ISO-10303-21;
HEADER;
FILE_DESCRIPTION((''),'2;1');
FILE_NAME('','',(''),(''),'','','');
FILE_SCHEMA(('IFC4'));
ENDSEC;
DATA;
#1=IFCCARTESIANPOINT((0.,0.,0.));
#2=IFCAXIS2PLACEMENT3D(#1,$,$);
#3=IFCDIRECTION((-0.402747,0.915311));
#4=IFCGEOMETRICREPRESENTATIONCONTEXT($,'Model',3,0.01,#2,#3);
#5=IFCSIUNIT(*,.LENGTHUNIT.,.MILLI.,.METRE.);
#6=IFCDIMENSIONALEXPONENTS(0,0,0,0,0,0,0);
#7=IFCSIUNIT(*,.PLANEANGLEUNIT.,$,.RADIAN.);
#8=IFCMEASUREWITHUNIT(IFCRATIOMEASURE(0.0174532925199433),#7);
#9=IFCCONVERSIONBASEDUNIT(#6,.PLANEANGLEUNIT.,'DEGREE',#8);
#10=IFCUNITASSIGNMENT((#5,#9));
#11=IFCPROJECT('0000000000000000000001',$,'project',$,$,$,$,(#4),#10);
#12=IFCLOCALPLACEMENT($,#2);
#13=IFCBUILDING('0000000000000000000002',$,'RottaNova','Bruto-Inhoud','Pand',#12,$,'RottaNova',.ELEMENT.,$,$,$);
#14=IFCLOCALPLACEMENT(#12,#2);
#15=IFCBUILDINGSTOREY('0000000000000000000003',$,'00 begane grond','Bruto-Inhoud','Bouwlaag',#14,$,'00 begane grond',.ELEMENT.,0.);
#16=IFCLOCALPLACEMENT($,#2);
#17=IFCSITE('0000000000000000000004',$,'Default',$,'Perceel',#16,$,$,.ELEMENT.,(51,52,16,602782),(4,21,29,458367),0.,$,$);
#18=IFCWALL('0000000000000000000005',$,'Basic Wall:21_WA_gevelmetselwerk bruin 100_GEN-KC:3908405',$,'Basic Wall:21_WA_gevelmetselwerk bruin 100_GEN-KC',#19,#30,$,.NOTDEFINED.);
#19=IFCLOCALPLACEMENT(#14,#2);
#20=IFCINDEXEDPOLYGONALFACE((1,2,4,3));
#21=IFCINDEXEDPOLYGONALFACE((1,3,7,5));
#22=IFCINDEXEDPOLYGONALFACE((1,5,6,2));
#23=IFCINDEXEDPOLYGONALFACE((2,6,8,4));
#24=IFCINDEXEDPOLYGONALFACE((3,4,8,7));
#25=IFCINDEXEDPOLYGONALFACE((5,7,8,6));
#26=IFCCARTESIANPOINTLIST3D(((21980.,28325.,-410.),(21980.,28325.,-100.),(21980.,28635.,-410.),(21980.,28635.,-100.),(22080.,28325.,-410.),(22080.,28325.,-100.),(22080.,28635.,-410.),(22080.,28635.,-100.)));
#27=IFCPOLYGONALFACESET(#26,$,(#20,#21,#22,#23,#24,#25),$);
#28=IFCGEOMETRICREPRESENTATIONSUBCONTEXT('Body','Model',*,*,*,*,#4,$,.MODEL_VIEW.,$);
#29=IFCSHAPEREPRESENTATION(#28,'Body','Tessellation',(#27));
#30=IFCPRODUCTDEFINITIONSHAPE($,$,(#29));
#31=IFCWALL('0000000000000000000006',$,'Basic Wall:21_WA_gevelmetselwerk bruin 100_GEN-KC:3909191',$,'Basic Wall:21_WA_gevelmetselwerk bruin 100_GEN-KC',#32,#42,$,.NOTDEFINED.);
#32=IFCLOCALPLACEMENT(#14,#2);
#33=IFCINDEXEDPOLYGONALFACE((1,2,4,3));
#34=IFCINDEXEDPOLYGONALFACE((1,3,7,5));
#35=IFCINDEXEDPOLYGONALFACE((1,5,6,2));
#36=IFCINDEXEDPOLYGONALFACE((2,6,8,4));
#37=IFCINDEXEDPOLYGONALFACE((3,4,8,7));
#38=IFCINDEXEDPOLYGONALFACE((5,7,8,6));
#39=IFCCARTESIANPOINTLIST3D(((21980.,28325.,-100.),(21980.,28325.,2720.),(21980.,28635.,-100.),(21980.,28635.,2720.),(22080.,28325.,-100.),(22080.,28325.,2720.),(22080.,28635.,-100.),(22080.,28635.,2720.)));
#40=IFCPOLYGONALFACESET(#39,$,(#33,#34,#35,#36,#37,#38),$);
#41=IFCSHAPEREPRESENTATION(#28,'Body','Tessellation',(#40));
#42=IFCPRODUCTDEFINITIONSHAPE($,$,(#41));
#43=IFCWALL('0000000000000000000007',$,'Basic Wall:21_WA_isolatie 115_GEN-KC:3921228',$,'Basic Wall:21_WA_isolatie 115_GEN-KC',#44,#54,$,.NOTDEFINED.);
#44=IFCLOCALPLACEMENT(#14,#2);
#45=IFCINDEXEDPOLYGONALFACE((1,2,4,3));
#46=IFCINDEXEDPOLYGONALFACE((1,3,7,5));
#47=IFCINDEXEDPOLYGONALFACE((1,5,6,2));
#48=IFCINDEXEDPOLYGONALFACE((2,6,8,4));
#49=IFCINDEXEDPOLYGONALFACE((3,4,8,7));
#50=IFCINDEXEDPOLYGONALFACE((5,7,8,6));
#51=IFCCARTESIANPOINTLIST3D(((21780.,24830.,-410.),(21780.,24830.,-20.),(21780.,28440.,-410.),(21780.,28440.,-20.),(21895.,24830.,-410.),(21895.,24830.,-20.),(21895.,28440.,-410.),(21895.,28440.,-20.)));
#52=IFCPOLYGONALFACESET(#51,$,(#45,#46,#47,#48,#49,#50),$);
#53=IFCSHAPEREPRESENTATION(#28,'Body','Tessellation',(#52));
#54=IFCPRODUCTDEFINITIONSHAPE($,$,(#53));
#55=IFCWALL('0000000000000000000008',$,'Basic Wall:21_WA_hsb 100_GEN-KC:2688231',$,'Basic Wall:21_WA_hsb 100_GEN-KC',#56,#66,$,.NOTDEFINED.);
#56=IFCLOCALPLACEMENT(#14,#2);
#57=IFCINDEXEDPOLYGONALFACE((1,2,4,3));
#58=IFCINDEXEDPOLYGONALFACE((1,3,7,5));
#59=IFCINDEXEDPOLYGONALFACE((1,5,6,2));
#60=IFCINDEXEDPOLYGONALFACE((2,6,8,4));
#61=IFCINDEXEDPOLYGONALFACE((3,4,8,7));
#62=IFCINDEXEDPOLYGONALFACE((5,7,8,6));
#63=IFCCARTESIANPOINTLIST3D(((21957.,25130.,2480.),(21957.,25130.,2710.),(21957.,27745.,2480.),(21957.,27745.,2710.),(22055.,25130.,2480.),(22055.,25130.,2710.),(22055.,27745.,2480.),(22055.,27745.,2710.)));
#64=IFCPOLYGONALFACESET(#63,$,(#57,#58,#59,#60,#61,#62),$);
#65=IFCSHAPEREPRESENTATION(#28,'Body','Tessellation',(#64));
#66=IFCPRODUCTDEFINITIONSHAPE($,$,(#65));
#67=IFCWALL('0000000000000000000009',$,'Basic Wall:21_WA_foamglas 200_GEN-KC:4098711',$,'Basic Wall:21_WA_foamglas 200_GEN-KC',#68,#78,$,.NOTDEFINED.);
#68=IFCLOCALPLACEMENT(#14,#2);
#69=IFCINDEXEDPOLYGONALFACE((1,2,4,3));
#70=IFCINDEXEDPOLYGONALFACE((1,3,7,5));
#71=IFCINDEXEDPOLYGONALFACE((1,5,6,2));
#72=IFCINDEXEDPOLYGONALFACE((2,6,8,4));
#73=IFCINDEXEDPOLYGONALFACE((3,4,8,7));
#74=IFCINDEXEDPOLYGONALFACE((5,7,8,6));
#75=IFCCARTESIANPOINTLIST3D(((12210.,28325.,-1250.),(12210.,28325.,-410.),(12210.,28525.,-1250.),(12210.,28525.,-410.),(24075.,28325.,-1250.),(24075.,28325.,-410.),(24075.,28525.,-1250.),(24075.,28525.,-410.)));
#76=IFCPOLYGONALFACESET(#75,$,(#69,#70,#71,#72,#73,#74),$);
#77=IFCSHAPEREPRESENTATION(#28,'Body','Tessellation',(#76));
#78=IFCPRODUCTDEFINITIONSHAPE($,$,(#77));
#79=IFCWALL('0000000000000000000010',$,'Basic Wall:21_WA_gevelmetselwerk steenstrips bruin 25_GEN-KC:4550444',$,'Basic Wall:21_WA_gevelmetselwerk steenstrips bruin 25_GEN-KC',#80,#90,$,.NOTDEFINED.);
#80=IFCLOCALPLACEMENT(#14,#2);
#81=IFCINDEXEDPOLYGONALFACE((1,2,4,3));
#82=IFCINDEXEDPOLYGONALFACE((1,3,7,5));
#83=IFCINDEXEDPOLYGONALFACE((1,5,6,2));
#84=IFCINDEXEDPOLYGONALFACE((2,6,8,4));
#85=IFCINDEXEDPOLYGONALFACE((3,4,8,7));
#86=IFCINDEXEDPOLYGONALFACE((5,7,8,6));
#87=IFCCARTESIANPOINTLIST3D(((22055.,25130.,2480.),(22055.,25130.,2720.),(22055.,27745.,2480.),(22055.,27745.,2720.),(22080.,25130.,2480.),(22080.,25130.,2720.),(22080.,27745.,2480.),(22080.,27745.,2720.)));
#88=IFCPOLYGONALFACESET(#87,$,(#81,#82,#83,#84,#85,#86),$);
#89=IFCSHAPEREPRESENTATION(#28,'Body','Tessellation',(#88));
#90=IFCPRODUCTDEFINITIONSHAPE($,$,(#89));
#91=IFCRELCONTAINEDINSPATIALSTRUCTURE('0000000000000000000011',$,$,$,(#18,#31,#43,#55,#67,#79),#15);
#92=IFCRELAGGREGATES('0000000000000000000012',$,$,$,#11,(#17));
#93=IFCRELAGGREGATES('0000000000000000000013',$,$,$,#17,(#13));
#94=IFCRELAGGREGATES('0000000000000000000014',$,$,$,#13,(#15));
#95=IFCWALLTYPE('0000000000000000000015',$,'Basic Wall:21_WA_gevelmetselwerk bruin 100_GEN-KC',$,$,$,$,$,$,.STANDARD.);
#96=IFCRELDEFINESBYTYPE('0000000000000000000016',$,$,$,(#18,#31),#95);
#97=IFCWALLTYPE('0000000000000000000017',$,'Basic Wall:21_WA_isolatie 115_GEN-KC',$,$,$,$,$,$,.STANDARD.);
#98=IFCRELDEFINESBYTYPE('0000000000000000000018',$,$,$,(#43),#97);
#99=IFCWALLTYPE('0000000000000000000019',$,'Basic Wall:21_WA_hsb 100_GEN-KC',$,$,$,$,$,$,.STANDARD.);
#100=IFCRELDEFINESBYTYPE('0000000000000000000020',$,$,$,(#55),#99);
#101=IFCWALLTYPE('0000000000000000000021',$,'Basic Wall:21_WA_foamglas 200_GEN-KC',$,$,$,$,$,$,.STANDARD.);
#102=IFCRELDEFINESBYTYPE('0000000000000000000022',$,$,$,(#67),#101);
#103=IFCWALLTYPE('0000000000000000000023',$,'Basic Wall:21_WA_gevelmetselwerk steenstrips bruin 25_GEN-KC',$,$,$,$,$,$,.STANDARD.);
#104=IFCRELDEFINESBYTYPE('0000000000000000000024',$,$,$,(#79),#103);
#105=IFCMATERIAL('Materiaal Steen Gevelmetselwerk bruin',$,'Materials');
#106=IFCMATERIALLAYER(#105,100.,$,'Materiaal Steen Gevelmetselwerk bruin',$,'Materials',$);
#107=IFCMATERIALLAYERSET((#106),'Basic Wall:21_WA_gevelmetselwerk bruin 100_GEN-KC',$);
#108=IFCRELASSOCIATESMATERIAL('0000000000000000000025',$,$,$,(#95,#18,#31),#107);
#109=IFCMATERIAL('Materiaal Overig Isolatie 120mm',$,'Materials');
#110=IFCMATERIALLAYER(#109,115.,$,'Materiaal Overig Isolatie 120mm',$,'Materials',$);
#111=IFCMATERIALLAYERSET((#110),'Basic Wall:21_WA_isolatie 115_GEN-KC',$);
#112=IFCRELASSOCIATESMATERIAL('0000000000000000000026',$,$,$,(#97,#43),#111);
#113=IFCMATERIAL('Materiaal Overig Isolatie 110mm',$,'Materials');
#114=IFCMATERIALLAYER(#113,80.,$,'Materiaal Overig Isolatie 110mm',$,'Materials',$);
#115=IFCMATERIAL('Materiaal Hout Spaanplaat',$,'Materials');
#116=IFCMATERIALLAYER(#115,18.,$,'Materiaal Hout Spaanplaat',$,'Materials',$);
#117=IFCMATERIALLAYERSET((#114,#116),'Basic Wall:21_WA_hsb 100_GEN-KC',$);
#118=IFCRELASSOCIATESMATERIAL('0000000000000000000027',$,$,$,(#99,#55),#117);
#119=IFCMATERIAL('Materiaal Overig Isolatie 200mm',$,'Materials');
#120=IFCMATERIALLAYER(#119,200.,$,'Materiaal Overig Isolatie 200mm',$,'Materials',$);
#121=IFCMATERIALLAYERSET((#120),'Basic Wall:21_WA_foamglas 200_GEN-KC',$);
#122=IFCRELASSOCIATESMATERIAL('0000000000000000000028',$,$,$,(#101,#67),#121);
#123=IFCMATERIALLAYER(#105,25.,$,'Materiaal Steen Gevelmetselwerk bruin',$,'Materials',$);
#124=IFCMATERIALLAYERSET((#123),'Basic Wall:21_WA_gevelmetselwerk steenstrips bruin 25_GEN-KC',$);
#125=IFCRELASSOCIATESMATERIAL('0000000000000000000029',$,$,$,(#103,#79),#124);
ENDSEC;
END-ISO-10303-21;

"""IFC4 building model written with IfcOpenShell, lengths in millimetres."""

from ifc_helpers import new_model, entity, si_unit, converted_unit, direction, frame, frame_2d, origin, place, context, subcontext, project, spatial, rectangle, extrude, material, layer, layer_set, type_object, element, save


model = new_model("IFC4")

# Units and contexts
model_context = context("Model", 3, precision=0.01, world=origin(), true_north=direction((-0.402747, 0.915311)))
body_context = subcontext(model_context, "Body", "Model", "MODEL_VIEW")
ifc_project = project(units=[si_unit("LENGTHUNIT", "METRE", prefix="MILLI"), converted_unit("PLANEANGLEUNIT", "DEGREE", entity("IfcRatioMeasure", 0.0174532925199433), si_unit("PLANEANGLEUNIT", "RADIAN"), dimensions=[0, 0, 0, 0, 0, 0, 0])], contexts=[model_context])

# Site, building, storey
site_placement = place(None, origin())
site = spatial("IfcSite", under=ifc_project, at=site_placement, Name="Default", ObjectType="Perceel", CompositionType="ELEMENT", RefLatitude=(51, 52, 16, 602782), RefLongitude=(4, 21, 29, 458367), RefElevation=0.0)
building_placement = place(None, origin())
building = spatial("IfcBuilding", under=site, at=building_placement, Name="RottaNova", Description="Bruto-Inhoud", ObjectType="Pand", LongName="RottaNova", CompositionType="ELEMENT")
storey_placement = place(building_placement, origin())
storey = spatial("IfcBuildingStorey", under=building, at=storey_placement, Name="00 begane grond", Description="Bruto-Inhoud", ObjectType="Bouwlaag", LongName="00 begane grond", CompositionType="ELEMENT", Elevation=0.0)

# Walls
ifc_material_1 = material(Name="Materiaal Steen Gevelmetselwerk bruin", Category="Materials")
ifc_layer_1 = layer(ifc_material_1, 100.0, Name="Materiaal Steen Gevelmetselwerk bruin", Category="Materials")
ifc_layer_set_1 = layer_set([ifc_layer_1], Name="Basic Wall:21_WA_gevelmetselwerk bruin 100_GEN-KC")
wall_type_1 = type_object("IfcWallType", Name="Basic Wall:21_WA_gevelmetselwerk bruin 100_GEN-KC", PredefinedType="STANDARD", material=ifc_layer_set_1)
wall_1_placement = place(storey_placement, frame((22030.0, 28325.0, -410.0), z_axis=(0.0, 0.0, 1.0), x_axis=(0.0, 1.0, 0.0)))
element("IfcWall", 1, at=wall_1_placement, inside=storey, type_object=wall_type_1, material=ifc_layer_set_1, Name="Basic Wall:21_WA_gevelmetselwerk bruin 100_GEN-KC:3908405", ObjectType="Basic Wall:21_WA_gevelmetselwerk bruin 100_GEN-KC", PredefinedType="NOTDEFINED", context=body_context, shape_type="SweptSolid", body=[
    extrude(rectangle(XDim=310.0, YDim=100.0, at=frame_2d((155.0, 0.0), x_axis=(-1.0, 0.0))), origin(), (0.0, 0.0, 1.0), 310.0),
])
wall_2_placement = place(storey_placement, frame((22030.0, 28325.0, -100.0), z_axis=(0.0, 0.0, 1.0), x_axis=(0.0, 1.0, 0.0)))
element("IfcWall", 2, at=wall_2_placement, inside=storey, type_object=wall_type_1, material=ifc_layer_set_1, Name="Basic Wall:21_WA_gevelmetselwerk bruin 100_GEN-KC:3909191", ObjectType="Basic Wall:21_WA_gevelmetselwerk bruin 100_GEN-KC", PredefinedType="NOTDEFINED", context=body_context, shape_type="SweptSolid", body=[
    extrude(rectangle(XDim=310.0, YDim=100.0, at=frame_2d((155.0, 0.0), x_axis=(-1.0, 0.0))), origin(), (0.0, 0.0, 1.0), 2820.0),
])
ifc_material_2 = material(Name="Materiaal Overig Isolatie 120mm", Category="Materials")
ifc_layer_2 = layer(ifc_material_2, 115.0, Name="Materiaal Overig Isolatie 120mm", Category="Materials")
ifc_layer_set_2 = layer_set([ifc_layer_2], Name="Basic Wall:21_WA_isolatie 115_GEN-KC")
wall_type_2 = type_object("IfcWallType", Name="Basic Wall:21_WA_isolatie 115_GEN-KC", PredefinedType="STANDARD", material=ifc_layer_set_2)
wall_3_placement = place(storey_placement, frame((21837.5, 28440.0, -410.0), z_axis=(0.0, 0.0, 1.0), x_axis=(0.0, -1.0, 0.0)))
element("IfcWall", 3, at=wall_3_placement, inside=storey, type_object=wall_type_2, material=ifc_layer_set_2, Name="Basic Wall:21_WA_isolatie 115_GEN-KC:3921228", ObjectType="Basic Wall:21_WA_isolatie 115_GEN-KC", PredefinedType="NOTDEFINED", context=body_context, shape_type="SweptSolid", body=[
    extrude(rectangle(XDim=3610.0, YDim=115.0, at=frame_2d((1805.0, 0.0), x_axis=(-1.0, 0.0))), origin(), (0.0, 0.0, 1.0), 390.0),
])
ifc_material_3 = material(Name="Materiaal Overig Isolatie 110mm", Category="Materials")
ifc_layer_3 = layer(ifc_material_3, 80.0, Name="Materiaal Overig Isolatie 110mm", Category="Materials")
ifc_material_4 = material(Name="Materiaal Hout Spaanplaat", Category="Materials")
ifc_layer_4 = layer(ifc_material_4, 18.0, Name="Materiaal Hout Spaanplaat", Category="Materials")
ifc_layer_set_3 = layer_set([ifc_layer_3, ifc_layer_4], Name="Basic Wall:21_WA_hsb 100_GEN-KC")
wall_type_3 = type_object("IfcWallType", Name="Basic Wall:21_WA_hsb 100_GEN-KC", PredefinedType="STANDARD", material=ifc_layer_set_3)
wall_4_placement = place(storey_placement, frame((22006.0, 25130.0, 2480.0), z_axis=(0.0, 0.0, 1.0), x_axis=(0.0, 1.0, 0.0)))
element("IfcWall", 4, at=wall_4_placement, inside=storey, type_object=wall_type_3, material=ifc_layer_set_3, Name="Basic Wall:21_WA_hsb 100_GEN-KC:2688231", ObjectType="Basic Wall:21_WA_hsb 100_GEN-KC", PredefinedType="NOTDEFINED", context=body_context, shape_type="SweptSolid", body=[
    extrude(rectangle(XDim=2615.0, YDim=98.0, at=frame_2d((1307.5, 0.0), x_axis=(-1.0, 0.0))), origin(), (0.0, 0.0, 1.0), 230.0),
])
ifc_material_5 = material(Name="Materiaal Overig Isolatie 200mm", Category="Materials")
ifc_layer_5 = layer(ifc_material_5, 200.0, Name="Materiaal Overig Isolatie 200mm", Category="Materials")
ifc_layer_set_4 = layer_set([ifc_layer_5], Name="Basic Wall:21_WA_foamglas 200_GEN-KC")
wall_type_4 = type_object("IfcWallType", Name="Basic Wall:21_WA_foamglas 200_GEN-KC", PredefinedType="STANDARD", material=ifc_layer_set_4)
wall_5_placement = place(storey_placement, frame((24075.0, 28425.0, -1250.0), z_axis=(0.0, 0.0, 1.0), x_axis=(-1.0, 0.0, 0.0)))
element("IfcWall", 5, at=wall_5_placement, inside=storey, type_object=wall_type_4, material=ifc_layer_set_4, Name="Basic Wall:21_WA_foamglas 200_GEN-KC:4098711", ObjectType="Basic Wall:21_WA_foamglas 200_GEN-KC", PredefinedType="NOTDEFINED", context=body_context, shape_type="SweptSolid", body=[
    extrude(rectangle(XDim=11865.0, YDim=200.0, at=frame_2d((5932.5, 0.0), x_axis=(-1.0, 0.0))), origin(), (0.0, 0.0, 1.0), 840.0),
])
ifc_layer_6 = layer(ifc_material_1, 25.0, Name="Materiaal Steen Gevelmetselwerk bruin", Category="Materials")
ifc_layer_set_5 = layer_set([ifc_layer_6], Name="Basic Wall:21_WA_gevelmetselwerk steenstrips bruin 25_GEN-KC")
wall_type_5 = type_object("IfcWallType", Name="Basic Wall:21_WA_gevelmetselwerk steenstrips bruin 25_GEN-KC", PredefinedType="STANDARD", material=ifc_layer_set_5)
wall_6_placement = place(storey_placement, frame((22067.5, 27745.0, 2480.0), z_axis=(0.0, 0.0, 1.0), x_axis=(0.0, -1.0, 0.0)))
element("IfcWall", 6, at=wall_6_placement, inside=storey, type_object=wall_type_5, material=ifc_layer_set_5, Name="Basic Wall:21_WA_gevelmetselwerk steenstrips bruin 25_GEN-KC:4550444", ObjectType="Basic Wall:21_WA_gevelmetselwerk steenstrips bruin 25_GEN-KC", PredefinedType="NOTDEFINED", context=body_context, shape_type="SweptSolid", body=[
    extrude(rectangle(XDim=2615.0, YDim=25.0, at=frame_2d((1307.5, 0.0), x_axis=(-1.0, 0.0))), origin(), (0.0, 0.0, 1.0), 240.0),
])

save(model, "model.ifc")
